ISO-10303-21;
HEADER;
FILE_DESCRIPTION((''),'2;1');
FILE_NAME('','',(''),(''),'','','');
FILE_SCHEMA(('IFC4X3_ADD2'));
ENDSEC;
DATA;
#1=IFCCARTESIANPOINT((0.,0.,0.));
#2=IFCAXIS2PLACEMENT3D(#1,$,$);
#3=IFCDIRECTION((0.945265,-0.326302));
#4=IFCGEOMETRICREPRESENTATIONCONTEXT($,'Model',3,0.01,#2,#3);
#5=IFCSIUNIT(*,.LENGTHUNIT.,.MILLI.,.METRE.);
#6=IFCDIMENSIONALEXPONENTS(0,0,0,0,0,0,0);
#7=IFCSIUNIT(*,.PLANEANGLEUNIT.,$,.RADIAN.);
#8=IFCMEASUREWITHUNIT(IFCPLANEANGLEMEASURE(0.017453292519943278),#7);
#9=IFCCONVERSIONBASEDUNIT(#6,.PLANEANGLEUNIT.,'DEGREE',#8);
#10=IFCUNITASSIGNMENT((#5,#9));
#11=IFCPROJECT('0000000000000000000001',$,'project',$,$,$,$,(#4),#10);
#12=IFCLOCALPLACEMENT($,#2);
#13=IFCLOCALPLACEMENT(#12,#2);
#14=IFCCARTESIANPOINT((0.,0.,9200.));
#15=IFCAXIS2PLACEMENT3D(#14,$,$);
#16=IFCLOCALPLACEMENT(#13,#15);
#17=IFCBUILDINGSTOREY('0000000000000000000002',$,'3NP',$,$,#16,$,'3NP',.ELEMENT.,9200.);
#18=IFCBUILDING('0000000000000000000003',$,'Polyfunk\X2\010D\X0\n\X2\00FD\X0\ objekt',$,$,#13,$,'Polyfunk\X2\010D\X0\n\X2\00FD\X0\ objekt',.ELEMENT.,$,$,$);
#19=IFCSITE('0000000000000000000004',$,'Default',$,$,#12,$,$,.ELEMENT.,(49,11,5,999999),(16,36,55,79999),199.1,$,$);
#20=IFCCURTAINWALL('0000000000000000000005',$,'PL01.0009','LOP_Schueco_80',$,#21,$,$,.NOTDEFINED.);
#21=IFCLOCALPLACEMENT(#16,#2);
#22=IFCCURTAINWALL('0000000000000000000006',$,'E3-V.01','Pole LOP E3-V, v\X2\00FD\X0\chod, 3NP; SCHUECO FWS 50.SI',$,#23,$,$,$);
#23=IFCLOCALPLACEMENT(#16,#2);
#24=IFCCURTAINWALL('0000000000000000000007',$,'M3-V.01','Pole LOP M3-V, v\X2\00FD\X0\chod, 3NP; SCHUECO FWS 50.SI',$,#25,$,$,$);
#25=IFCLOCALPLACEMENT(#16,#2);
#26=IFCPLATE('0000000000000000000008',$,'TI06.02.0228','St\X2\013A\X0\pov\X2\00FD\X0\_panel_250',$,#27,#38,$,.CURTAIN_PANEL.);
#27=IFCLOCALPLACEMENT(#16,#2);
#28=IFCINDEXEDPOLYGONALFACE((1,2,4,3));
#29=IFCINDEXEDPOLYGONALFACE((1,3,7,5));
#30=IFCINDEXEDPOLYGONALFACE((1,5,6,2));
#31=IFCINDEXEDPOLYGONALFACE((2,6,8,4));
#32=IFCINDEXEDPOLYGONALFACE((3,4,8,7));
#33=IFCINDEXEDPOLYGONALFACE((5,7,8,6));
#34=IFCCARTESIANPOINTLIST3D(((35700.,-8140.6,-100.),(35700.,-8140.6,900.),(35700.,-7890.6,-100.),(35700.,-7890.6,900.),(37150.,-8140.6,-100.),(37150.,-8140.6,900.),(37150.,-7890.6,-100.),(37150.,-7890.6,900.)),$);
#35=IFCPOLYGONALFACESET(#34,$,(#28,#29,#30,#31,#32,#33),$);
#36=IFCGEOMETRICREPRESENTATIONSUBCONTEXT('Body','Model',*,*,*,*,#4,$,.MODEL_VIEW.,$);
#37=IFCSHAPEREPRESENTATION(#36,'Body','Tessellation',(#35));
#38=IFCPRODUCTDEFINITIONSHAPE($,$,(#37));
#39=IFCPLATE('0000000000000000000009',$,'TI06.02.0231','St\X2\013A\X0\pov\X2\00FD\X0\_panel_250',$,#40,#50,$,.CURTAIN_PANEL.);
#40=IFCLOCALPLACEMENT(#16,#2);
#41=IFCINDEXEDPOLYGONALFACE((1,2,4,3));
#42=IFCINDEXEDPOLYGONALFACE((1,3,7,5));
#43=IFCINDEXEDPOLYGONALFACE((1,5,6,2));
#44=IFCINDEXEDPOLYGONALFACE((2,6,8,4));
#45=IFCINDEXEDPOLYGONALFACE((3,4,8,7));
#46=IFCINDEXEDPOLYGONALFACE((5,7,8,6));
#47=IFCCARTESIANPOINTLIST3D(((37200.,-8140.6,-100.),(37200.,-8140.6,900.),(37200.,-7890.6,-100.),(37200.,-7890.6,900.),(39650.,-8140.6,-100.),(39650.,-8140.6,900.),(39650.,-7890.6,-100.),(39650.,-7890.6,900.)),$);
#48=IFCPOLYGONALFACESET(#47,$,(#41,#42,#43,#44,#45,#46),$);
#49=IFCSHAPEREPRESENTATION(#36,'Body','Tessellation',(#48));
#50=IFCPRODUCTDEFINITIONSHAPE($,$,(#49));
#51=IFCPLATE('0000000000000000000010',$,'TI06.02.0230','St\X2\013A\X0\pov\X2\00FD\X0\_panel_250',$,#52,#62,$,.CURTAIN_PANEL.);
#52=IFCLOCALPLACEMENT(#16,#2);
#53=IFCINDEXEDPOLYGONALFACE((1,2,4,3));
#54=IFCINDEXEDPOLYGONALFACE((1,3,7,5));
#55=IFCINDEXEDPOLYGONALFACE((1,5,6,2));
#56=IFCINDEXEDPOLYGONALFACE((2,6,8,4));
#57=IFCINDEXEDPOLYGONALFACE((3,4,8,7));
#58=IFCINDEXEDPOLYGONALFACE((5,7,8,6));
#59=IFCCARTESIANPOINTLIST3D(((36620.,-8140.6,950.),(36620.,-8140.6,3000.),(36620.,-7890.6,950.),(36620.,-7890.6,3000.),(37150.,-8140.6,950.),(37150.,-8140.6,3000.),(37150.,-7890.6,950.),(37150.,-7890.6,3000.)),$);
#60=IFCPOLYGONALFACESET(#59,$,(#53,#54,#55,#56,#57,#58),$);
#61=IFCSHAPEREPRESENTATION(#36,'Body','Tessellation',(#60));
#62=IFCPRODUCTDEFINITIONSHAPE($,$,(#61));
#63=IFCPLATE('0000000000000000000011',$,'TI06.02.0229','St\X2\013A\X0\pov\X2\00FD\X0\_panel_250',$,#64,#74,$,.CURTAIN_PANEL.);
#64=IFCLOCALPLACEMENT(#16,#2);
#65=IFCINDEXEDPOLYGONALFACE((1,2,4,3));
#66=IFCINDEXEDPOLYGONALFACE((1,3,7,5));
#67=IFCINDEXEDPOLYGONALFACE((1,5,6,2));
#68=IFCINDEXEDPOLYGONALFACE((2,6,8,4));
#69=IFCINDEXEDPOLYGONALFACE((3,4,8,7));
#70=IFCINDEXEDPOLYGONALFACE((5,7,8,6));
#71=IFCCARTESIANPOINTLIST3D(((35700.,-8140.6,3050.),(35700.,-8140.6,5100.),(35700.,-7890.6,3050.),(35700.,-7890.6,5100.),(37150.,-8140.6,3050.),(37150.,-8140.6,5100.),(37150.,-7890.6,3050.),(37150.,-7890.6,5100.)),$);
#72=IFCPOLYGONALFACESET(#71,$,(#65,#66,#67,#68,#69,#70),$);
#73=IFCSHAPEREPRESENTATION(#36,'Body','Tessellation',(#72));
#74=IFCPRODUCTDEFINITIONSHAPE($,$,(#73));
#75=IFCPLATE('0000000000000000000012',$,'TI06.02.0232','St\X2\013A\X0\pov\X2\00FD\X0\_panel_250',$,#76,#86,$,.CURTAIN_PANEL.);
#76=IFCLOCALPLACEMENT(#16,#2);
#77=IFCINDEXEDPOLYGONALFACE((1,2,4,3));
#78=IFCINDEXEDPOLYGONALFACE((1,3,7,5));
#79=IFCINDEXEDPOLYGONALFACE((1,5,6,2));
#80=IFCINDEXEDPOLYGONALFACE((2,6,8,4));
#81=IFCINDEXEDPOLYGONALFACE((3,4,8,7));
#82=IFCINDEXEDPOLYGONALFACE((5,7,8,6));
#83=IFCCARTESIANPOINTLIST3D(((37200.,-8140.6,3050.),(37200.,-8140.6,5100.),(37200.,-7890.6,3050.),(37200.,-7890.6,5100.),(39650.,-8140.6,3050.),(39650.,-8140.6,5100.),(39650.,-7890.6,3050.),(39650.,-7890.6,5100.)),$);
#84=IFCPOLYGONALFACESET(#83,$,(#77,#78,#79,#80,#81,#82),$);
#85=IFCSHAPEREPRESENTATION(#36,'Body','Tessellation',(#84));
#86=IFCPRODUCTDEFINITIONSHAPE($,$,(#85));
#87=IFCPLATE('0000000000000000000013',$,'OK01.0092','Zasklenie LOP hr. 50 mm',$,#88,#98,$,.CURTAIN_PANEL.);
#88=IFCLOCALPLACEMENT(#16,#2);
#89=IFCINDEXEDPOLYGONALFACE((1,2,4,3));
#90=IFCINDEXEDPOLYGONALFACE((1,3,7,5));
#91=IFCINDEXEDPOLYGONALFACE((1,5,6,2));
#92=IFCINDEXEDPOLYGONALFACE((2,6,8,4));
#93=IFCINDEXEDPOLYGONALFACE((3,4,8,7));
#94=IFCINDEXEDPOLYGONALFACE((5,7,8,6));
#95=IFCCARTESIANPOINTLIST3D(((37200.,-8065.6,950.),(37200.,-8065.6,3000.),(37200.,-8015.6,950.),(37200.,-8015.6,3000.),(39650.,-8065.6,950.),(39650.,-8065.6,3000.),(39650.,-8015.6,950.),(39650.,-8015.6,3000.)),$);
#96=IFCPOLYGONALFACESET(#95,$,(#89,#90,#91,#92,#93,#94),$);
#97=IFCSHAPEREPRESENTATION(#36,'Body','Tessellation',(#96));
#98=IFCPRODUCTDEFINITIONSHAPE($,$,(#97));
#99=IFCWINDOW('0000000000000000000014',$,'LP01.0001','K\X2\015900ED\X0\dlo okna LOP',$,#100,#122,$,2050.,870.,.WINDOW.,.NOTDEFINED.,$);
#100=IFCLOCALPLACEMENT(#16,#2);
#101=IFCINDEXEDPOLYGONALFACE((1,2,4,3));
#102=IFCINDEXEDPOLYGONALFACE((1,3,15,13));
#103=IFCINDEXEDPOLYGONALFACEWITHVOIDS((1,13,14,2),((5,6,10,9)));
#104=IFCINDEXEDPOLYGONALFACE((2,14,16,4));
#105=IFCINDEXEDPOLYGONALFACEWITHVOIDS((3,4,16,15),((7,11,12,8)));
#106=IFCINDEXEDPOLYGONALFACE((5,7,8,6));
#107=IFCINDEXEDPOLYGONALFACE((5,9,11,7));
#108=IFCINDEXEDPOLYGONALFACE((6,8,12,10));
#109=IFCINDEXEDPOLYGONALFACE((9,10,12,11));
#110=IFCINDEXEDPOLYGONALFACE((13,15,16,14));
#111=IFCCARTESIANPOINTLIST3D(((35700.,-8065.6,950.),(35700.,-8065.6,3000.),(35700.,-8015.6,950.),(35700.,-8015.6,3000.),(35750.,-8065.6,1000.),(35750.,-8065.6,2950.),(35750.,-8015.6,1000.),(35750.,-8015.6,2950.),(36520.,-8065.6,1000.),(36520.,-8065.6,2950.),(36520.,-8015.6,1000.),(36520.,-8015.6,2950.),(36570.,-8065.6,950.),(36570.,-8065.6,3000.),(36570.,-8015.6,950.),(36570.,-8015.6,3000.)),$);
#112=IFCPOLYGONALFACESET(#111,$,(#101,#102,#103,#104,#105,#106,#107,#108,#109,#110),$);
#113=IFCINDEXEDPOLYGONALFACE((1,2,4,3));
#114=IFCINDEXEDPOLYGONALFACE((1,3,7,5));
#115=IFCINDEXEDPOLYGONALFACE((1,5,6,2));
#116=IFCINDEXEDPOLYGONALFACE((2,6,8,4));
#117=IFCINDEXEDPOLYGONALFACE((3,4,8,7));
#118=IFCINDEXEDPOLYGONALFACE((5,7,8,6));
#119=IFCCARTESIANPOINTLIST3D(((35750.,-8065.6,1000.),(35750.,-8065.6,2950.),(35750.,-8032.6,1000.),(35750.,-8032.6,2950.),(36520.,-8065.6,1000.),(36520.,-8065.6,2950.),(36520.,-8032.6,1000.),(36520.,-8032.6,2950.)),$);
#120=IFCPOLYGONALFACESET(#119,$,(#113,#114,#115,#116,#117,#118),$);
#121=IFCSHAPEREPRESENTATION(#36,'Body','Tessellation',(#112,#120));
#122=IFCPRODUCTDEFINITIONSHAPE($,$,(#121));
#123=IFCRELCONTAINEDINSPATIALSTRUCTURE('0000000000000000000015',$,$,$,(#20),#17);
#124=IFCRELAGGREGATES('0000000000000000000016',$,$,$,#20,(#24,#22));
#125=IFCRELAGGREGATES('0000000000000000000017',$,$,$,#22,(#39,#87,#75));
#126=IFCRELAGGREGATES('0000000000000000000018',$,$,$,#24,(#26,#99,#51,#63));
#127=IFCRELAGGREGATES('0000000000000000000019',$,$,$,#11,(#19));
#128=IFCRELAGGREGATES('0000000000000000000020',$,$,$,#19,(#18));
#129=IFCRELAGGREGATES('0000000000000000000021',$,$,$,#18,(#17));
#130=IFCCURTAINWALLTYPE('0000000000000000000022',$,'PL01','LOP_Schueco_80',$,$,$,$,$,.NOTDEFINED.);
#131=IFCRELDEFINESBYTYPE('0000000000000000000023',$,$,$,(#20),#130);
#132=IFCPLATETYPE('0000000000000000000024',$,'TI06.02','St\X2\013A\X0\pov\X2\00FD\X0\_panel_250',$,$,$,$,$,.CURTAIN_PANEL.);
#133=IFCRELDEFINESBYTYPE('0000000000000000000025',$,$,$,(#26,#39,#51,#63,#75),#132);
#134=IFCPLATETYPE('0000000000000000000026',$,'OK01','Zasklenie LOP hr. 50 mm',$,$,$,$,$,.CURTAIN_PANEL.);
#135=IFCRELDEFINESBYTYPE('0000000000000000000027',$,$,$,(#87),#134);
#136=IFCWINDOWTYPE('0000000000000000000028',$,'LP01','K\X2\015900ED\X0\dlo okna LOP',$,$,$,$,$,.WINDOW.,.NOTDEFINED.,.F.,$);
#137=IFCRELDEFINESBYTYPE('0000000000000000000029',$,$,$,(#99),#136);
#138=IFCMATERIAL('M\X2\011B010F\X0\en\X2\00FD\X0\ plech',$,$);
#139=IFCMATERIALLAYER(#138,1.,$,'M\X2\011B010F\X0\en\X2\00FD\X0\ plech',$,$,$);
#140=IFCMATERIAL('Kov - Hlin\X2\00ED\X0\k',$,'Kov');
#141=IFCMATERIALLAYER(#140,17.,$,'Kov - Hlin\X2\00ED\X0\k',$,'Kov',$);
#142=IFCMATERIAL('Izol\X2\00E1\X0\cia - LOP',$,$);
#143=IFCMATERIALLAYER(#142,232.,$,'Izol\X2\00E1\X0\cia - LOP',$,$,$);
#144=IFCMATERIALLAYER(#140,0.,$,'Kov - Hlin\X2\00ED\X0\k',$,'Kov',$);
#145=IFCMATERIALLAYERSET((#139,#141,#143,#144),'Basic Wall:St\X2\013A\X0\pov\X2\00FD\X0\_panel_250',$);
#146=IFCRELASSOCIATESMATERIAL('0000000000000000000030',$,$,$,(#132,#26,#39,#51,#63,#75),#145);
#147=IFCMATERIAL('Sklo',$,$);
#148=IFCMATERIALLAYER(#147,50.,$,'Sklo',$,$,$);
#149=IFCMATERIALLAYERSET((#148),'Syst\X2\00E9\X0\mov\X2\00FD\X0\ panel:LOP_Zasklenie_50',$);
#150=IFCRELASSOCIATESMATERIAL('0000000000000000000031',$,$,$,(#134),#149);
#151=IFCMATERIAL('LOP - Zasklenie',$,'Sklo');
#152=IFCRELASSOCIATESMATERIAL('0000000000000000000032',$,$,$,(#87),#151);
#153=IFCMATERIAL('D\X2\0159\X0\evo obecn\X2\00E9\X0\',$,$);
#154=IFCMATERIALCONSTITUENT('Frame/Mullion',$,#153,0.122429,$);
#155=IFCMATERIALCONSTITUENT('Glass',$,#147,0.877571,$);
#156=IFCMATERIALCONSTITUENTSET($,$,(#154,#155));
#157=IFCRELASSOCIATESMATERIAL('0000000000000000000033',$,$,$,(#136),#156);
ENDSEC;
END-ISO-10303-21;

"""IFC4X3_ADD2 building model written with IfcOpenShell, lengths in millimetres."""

from ifc_helpers import new_model, entity, si_unit, converted_unit, direction, frame, frame_2d, origin, origin_2d_with_axis, place, context, subcontext, project, spatial, polyline, rectangle, outline, extrude, source, transform, mapped, material, layer, layer_set, layer_usage, constituent, constituent_set, type_object, type_shapes, element, aggregate, save


model = new_model("IFC4X3_ADD2")

# Units and contexts
model_context = context("Model", 3, precision=0.01, world=origin(), true_north=direction((0.945265, -0.326302)))
body_context = subcontext(model_context, "Body", "Model", "MODEL_VIEW")
ifc_project = project(units=[si_unit("LENGTHUNIT", "METRE", prefix="MILLI"), converted_unit("PLANEANGLEUNIT", "DEGREE", entity("IfcPlaneAngleMeasure", 0.017453292519943278), si_unit("PLANEANGLEUNIT", "RADIAN"), dimensions=[0, 0, 0, 0, 0, 0, 0])], contexts=[model_context])

# Site, building, storey
site_placement = place(None, origin())
site = spatial("IfcSite", under=ifc_project, at=site_placement, Name="Default", CompositionType="ELEMENT", RefLatitude=(49, 11, 5, 999999), RefLongitude=(16, 36, 55, 79999), RefElevation=199.1)
building_placement = place(site_placement, origin())
building = spatial("IfcBuilding", under=site, at=building_placement, Name="Polyfunkčný objekt", LongName="Polyfunkčný objekt", CompositionType="ELEMENT")
storey_placement = place(building_placement, frame((0.0, 0.0, 9200.0)))
storey = spatial("IfcBuildingStorey", under=building, at=storey_placement, Name="3NP", LongName="3NP", CompositionType="ELEMENT", Elevation=9200.0)

# Curtain walls, plates, window
curtain_wall_type = type_object("IfcCurtainWallType", Name="PL01", Description="LOP_Schueco_80", PredefinedType="NOTDEFINED")
curtain_wall_1_placement = place(storey_placement, frame((0.0, 0.0, -9200.0)))
curtain_wall_1 = element("IfcCurtainWall", 1, at=curtain_wall_1_placement, inside=storey, type_object=curtain_wall_type, Name="PL01.0009", Description="LOP_Schueco_80", PredefinedType="NOTDEFINED")
curtain_wall_2 = element("IfcCurtainWall", 2, Name="E3-V.01", Description="Pole LOP E3-V, východ, 3NP; SCHUECO FWS 50.SI")
curtain_wall_3 = element("IfcCurtainWall", 3, Name="M3-V.01", Description="Pole LOP M3-V, východ, 3NP; SCHUECO FWS 50.SI")
aggregate(curtain_wall_1, [curtain_wall_3, curtain_wall_2])
ifc_material_1 = material(Name="Měďený plech")
ifc_layer_1 = layer(ifc_material_1, 1.0, Name="Měďený plech")
ifc_material_2 = material(Name="Kov - Hliník", Category="Kov")
ifc_layer_2 = layer(ifc_material_2, 17.0, Name="Kov - Hliník", Category="Kov")
ifc_material_3 = material(Name="Izolácia - LOP")
ifc_layer_3 = layer(ifc_material_3, 232.0, Name="Izolácia - LOP")
ifc_layer_4 = layer(ifc_material_2, 0.0, Name="Kov - Hliník", Category="Kov")
ifc_layer_set_1 = layer_set([ifc_layer_1, ifc_layer_2, ifc_layer_3, ifc_layer_4], Name="Basic Wall:Stĺpový_panel_250")
ifc_layer_usage_1 = layer_usage(ifc_layer_set_1, "AXIS2", "POSITIVE", -125.0)
plate_type_1 = type_object("IfcPlateType", Name="TI06.02", Description="Stĺpový_panel_250", PredefinedType="CURTAIN_PANEL", material=ifc_layer_set_1)
plate_1_placement = place(storey_placement, frame((35700.0, -8015.6, -100.0)))
plate_1 = element("IfcPlate", 4, at=plate_1_placement, type_object=plate_type_1, material=ifc_layer_usage_1, Name="TI06.02.0228", Description="Stĺpový_panel_250", PredefinedType="CURTAIN_PANEL", context=body_context, shape_type="SweptSolid", body=[
    extrude(rectangle(XDim=250.0, YDim=1450.0, at=frame_2d((0.0, 0.0), x_axis=(1.0, 0.0))), frame((725.0, 0.0, 0.0), z_axis=(0.0, 0.0, 1.0), x_axis=(0.0, 1.0, 0.0)), (0.0, 0.0, 1.0), 1000.0),
])
ifc_layer_usage_2 = layer_usage(ifc_layer_set_1, "AXIS2", "POSITIVE", -125.0)
plate_2_placement = place(storey_placement, frame((37200.0, -8015.6, -100.0)))
plate_2 = element("IfcPlate", 5, at=plate_2_placement, type_object=plate_type_1, material=ifc_layer_usage_2, Name="TI06.02.0231", Description="Stĺpový_panel_250", PredefinedType="CURTAIN_PANEL", context=body_context, shape_type="SweptSolid", body=[
    extrude(rectangle(XDim=250.0, YDim=2450.0, at=frame_2d((0.0, 0.0), x_axis=(1.0, 0.0))), frame((1225.0, 0.0, 0.0), z_axis=(0.0, 0.0, 1.0), x_axis=(0.0, 1.0, 0.0)), (0.0, 0.0, 1.0), 1000.0),
])
ifc_layer_usage_3 = layer_usage(ifc_layer_set_1, "AXIS2", "POSITIVE", -125.0)
plate_3_placement = place(storey_placement, frame((36620.0, -8015.6, 950.0)))
plate_3 = element("IfcPlate", 6, at=plate_3_placement, type_object=plate_type_1, material=ifc_layer_usage_3, Name="TI06.02.0230", Description="Stĺpový_panel_250", PredefinedType="CURTAIN_PANEL", context=body_context, shape_type="SweptSolid", body=[
    extrude(rectangle(XDim=250.0, YDim=530.0, at=frame_2d((0.0, 0.0), x_axis=(1.0, 0.0))), frame((265.0, 0.0, 0.0), z_axis=(0.0, 0.0, 1.0), x_axis=(0.0, 1.0, 0.0)), (0.0, 0.0, 1.0), 2050.0),
])
ifc_layer_usage_4 = layer_usage(ifc_layer_set_1, "AXIS2", "POSITIVE", -125.0)
plate_4_placement = place(storey_placement, frame((35700.0, -8015.6, 3050.0)))
plate_4 = element("IfcPlate", 7, at=plate_4_placement, type_object=plate_type_1, material=ifc_layer_usage_4, Name="TI06.02.0229", Description="Stĺpový_panel_250", PredefinedType="CURTAIN_PANEL", context=body_context, shape_type="SweptSolid", body=[
    extrude(rectangle(XDim=250.0, YDim=1450.0, at=frame_2d((0.0, 0.0), x_axis=(1.0, 0.0))), frame((725.0, 0.0, 0.0), z_axis=(0.0, 0.0, 1.0), x_axis=(0.0, 1.0, 0.0)), (0.0, 0.0, 1.0), 2050.0),
])
ifc_layer_usage_5 = layer_usage(ifc_layer_set_1, "AXIS2", "POSITIVE", -125.0)
plate_5_placement = place(storey_placement, frame((37200.0, -8015.6, 3050.0)))
plate_5 = element("IfcPlate", 8, at=plate_5_placement, type_object=plate_type_1, material=ifc_layer_usage_5, Name="TI06.02.0232", Description="Stĺpový_panel_250", PredefinedType="CURTAIN_PANEL", context=body_context, shape_type="SweptSolid", body=[
    extrude(rectangle(XDim=250.0, YDim=2450.0, at=frame_2d((0.0, 0.0), x_axis=(1.0, 0.0))), frame((1225.0, 0.0, 0.0), z_axis=(0.0, 0.0, 1.0), x_axis=(0.0, 1.0, 0.0)), (0.0, 0.0, 1.0), 2050.0),
])
ifc_material_4 = material(Name="LOP - Zasklenie", Category="Sklo")
ifc_material_5 = material(Name="Sklo")
ifc_layer_5 = layer(ifc_material_5, 50.0, Name="Sklo")
ifc_layer_set_2 = layer_set([ifc_layer_5], Name="Systémový panel:LOP_Zasklenie_50")
plate_type_2 = type_object("IfcPlateType", Name="OK01", Description="Zasklenie LOP hr. 50 mm", PredefinedType="CURTAIN_PANEL", material=ifc_layer_set_2)
shared_shape_1 = source(origin(), body_context, "Body", "SweptSolid", [
    extrude(rectangle(XDim=50.0, YDim=2450.0, at=origin_2d_with_axis()), frame((0.0, -25.0, 0.0), z_axis=(0.0, 0.0, 1.0), x_axis=(0.0, 1.0, 0.0)), (0.0, 0.0, 1.0), 2050.0),
])
type_shapes(plate_type_2, [shared_shape_1])
plate_6_placement = place(curtain_wall_1_placement, frame((38425.0, -8015.6, 10150.0)))
plate_6 = element("IfcPlate", 9, at=plate_6_placement, type_object=plate_type_2, material=ifc_material_4, Name="OK01.0092", Description="Zasklenie LOP hr. 50 mm", PredefinedType="CURTAIN_PANEL", context=body_context, shape_type="MappedRepresentation", body=[
    mapped(shared_shape_1, transform((0.0, 0.0, 0.0), scale=1.0)),
])
aggregate(curtain_wall_2, [plate_2, plate_6, plate_5])
ifc_material_6 = material(Name="Dřevo obecné")
ifc_constituent_1 = constituent(ifc_material_6, Name="Frame/Mullion", fraction=0.122429)
ifc_constituent_2 = constituent(ifc_material_5, Name="Glass", fraction=0.877571)
ifc_constituent_set = constituent_set(constituents=[ifc_constituent_1, ifc_constituent_2])
window_type = type_object("IfcWindowType", Name="LP01", Description="Křídlo okna LOP", ParameterTakesPrecedence=False, PartitioningType="NOTDEFINED", PredefinedType="WINDOW", material=ifc_constituent_set)
shared_shape_2 = source(origin(), body_context, "Body", "SweptSolid", [
    extrude(outline(polyline([(-1025.0, -435.0), (1025.0, -435.0), (1025.0, 435.0), (-1025.0, 435.0), (-1025.0, -435.0)]), holes=[polyline([(-975.0, -385.0), (-975.0, 385.0), (975.0, 385.0), (975.0, -385.0), (-975.0, -385.0)])]), frame((0.0, 50.0, 1025.0), z_axis=(0.0, -1.0, 0.0), x_axis=(0.0, 0.0, -1.0)), (0.0, 0.0, 1.0), 50.0),
    extrude(rectangle(XDim=770.0, YDim=33.0, at=frame_2d((0.0, 0.0), x_axis=(1.0, 0.0))), frame((0.0, 33.5, 50.0), z_axis=(0.0, 0.0, 1.0), x_axis=(-1.0, 0.0, 0.0)), (0.0, 0.0, 1.0), 1950.0),
])
type_shapes(window_type, [shared_shape_2])
window_placement = place(curtain_wall_1_placement, frame((36135.0, -8015.6, 10150.0), z_axis=(0.0, 0.0, 1.0), x_axis=(-1.0, 0.0, 0.0)))
window = element("IfcWindow", 10, at=window_placement, type_object=window_type, Name="LP01.0001", Description="Křídlo okna LOP", OverallHeight=2050.0, OverallWidth=870.0, PartitioningType="NOTDEFINED", PredefinedType="WINDOW", context=body_context, shape_type="MappedRepresentation", body=[
    mapped(shared_shape_2, transform((0.0, 0.0, 0.0), scale=1.0)),
])
aggregate(curtain_wall_3, [plate_1, window, plate_3, plate_4])

save(model, "model.ifc")
